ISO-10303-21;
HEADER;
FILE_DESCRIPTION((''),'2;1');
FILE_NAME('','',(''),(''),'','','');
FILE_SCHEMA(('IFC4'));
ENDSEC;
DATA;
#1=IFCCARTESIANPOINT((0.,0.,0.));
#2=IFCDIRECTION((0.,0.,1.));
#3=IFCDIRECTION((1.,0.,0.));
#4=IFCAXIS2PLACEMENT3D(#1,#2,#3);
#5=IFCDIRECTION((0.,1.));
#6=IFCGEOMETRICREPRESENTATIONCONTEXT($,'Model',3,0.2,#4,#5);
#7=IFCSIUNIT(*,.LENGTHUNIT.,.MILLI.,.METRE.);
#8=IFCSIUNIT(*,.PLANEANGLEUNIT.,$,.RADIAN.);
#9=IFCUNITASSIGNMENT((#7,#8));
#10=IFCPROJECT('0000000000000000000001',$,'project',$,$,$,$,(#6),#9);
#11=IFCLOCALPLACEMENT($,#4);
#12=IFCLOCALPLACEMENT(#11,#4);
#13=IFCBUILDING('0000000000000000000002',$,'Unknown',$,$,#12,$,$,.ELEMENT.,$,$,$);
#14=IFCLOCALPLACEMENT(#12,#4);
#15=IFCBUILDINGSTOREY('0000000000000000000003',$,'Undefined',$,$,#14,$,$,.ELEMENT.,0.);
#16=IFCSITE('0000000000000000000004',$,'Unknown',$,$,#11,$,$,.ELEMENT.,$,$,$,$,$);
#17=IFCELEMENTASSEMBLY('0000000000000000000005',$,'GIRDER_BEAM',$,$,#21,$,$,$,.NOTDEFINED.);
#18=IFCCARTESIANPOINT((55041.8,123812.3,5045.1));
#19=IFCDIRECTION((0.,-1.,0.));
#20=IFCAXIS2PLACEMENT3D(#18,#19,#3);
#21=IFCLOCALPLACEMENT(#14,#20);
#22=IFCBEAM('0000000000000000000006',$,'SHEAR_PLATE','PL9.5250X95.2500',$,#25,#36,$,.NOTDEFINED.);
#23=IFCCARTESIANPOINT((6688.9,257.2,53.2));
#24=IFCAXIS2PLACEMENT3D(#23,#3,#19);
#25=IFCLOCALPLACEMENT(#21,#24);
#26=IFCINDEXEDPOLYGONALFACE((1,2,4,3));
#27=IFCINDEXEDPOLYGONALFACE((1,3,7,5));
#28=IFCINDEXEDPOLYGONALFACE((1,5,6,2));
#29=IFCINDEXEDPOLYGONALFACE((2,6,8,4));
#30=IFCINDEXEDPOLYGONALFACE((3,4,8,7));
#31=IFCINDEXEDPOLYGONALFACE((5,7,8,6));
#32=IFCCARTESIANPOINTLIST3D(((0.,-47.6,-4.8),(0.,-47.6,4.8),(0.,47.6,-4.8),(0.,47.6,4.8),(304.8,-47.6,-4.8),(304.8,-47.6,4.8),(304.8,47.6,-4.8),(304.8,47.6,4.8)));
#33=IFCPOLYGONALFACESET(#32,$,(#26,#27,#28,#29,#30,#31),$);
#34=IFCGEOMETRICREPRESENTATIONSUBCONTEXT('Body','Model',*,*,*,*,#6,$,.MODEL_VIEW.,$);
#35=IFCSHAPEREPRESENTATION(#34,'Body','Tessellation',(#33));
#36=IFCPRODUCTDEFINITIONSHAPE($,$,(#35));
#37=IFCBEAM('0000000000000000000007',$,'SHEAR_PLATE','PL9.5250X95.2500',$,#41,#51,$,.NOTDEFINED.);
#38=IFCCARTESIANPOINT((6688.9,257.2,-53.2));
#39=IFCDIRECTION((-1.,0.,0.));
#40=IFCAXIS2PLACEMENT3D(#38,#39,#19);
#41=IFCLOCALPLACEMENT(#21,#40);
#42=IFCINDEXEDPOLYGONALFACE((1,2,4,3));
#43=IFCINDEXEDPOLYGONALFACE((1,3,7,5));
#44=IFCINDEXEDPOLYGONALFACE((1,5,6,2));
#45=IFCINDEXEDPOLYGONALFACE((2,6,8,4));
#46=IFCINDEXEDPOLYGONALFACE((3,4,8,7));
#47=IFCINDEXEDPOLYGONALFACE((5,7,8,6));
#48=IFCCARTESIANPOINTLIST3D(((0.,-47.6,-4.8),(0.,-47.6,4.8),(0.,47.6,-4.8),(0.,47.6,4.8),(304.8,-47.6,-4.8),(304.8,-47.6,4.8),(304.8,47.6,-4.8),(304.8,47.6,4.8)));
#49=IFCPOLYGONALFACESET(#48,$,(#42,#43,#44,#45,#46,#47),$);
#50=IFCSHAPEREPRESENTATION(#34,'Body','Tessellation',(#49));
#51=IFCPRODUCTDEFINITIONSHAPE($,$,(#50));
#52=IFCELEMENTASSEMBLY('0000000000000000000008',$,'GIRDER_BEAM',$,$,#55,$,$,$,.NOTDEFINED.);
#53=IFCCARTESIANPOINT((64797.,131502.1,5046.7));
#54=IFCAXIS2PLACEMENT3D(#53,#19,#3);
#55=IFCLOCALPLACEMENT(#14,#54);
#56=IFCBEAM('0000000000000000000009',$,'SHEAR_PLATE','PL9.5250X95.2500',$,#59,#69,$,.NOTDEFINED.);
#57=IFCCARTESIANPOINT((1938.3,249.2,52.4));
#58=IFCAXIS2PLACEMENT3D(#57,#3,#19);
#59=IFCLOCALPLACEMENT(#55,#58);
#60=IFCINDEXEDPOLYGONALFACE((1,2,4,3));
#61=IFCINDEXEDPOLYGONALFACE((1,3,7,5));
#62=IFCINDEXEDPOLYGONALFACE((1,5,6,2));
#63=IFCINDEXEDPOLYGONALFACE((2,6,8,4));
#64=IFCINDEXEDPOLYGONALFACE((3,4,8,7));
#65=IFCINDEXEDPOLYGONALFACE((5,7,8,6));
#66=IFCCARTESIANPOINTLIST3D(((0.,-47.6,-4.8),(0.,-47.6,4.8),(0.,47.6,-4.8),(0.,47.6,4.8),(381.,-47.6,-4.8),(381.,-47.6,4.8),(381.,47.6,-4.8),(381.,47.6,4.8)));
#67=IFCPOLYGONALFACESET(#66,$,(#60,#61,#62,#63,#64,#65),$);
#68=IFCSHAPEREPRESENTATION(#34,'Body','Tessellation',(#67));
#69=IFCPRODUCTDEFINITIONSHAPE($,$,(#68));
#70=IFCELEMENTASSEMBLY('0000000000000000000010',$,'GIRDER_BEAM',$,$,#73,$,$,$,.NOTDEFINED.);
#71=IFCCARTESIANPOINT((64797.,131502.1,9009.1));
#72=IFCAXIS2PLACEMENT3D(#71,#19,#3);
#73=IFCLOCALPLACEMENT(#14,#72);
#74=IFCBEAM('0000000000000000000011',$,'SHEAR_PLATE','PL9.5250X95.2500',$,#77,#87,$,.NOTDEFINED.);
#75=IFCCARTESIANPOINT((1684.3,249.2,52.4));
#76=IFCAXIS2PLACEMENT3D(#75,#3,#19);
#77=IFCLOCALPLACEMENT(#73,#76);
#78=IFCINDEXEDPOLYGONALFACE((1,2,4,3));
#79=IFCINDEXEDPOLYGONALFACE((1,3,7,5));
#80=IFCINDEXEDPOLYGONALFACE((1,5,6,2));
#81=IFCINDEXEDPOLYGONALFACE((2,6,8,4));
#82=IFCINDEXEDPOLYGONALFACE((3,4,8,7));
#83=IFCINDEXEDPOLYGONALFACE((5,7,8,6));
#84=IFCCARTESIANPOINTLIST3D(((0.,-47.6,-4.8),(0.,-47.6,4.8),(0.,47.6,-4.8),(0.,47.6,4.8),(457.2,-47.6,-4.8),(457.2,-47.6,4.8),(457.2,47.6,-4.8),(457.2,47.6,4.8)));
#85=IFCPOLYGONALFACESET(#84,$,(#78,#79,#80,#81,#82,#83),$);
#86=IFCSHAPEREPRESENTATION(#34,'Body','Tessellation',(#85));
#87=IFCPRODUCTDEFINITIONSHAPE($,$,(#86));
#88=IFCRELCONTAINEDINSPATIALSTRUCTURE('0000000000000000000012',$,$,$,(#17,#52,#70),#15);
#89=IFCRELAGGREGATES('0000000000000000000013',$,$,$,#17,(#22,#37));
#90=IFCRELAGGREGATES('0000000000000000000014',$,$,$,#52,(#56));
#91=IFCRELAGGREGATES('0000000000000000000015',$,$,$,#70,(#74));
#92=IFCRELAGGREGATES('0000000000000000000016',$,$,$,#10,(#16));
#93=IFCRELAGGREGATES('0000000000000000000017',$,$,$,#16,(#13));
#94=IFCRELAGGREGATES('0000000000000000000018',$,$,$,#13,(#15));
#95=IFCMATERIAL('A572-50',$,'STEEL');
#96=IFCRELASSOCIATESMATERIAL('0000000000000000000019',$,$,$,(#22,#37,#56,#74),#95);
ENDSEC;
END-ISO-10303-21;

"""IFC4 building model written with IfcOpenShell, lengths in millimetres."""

from ifc_helpers import new_model, si_unit, direction, frame, origin_with_axes, place, context, subcontext, project, spatial, line, indexed_curve, outline, extrude, material, element, aggregate, save


model = new_model("IFC4")

# Units and contexts
model_context = context("Model", 3, precision=0.2, world=origin_with_axes(), true_north=direction((0.0, 1.0)))
body_context = subcontext(model_context, "Body", "Model", "MODEL_VIEW")
ifc_project = project(units=[si_unit("LENGTHUNIT", "METRE", prefix="MILLI"), si_unit("PLANEANGLEUNIT", "RADIAN")], contexts=[model_context])

# Site, building, storey
site_placement = place(None, origin_with_axes())
site = spatial("IfcSite", under=ifc_project, at=site_placement, Name="Unknown", CompositionType="ELEMENT")
building_placement = place(site_placement, origin_with_axes())
building = spatial("IfcBuilding", under=site, at=building_placement, Name="Unknown", CompositionType="ELEMENT")
storey_placement = place(building_placement, origin_with_axes())
storey = spatial("IfcBuildingStorey", under=building, at=storey_placement, Name="Undefined", CompositionType="ELEMENT", Elevation=0.0)

# Element assembly, beams
assembly_1_placement = place(storey_placement, frame((55041.8, 123812.3, 5045.1), z_axis=(0.0, -1.0, 0.0), x_axis=(1.0, 0.0, 0.0)))
assembly_1 = element("IfcElementAssembly", 1, at=assembly_1_placement, inside=storey, Name="GIRDER_BEAM", PredefinedType="NOTDEFINED")
ifc_material_1 = material(Name="A572-50", Category="STEEL")
beam_1_placement = place(assembly_1_placement, frame((6688.9, 257.2, 53.2), z_axis=(1.0, 0.0, 0.0), x_axis=(0.0, -1.0, 0.0)))
beam_1 = element("IfcBeam", 2, at=beam_1_placement, material=ifc_material_1, Name="SHEAR_PLATE", Description="PL9.5250X95.2500", PredefinedType="NOTDEFINED", context=body_context, shape_type="SolidModel", body=[
    extrude(outline(indexed_curve([(-4.8, -47.6), (4.8, -47.6), (4.8, 47.6), (-4.8, 47.6)], segments=[line(1, 2, 3, 4, 1)])), frame((0.0, 0.0, 0.0), z_axis=(-1.0, 0.0, 0.0), x_axis=(0.0, 0.0, 1.0)), (0.0, 0.0, -1.0), 304.8),
])
beam_2_placement = place(assembly_1_placement, frame((6688.9, 257.2, -53.2), z_axis=(-1.0, 0.0, 0.0), x_axis=(0.0, -1.0, 0.0)))
beam_2 = element("IfcBeam", 3, at=beam_2_placement, material=ifc_material_1, Name="SHEAR_PLATE", Description="PL9.5250X95.2500", PredefinedType="NOTDEFINED", context=body_context, shape_type="SolidModel", body=[
    extrude(outline(indexed_curve([(-4.8, -47.6), (4.8, -47.6), (4.8, 47.6), (-4.8, 47.6)], segments=[line(1, 2, 3, 4, 1)])), frame((0.0, 0.0, 0.0), z_axis=(-1.0, 0.0, 0.0), x_axis=(0.0, 0.0, 1.0)), (0.0, 0.0, -1.0), 304.8),
])
aggregate(assembly_1, [beam_1, beam_2])

# Element assemblies, beams
assembly_2_placement = place(storey_placement, frame((64797.0, 131502.1, 5046.7), z_axis=(0.0, -1.0, 0.0), x_axis=(1.0, 0.0, 0.0)))
assembly_2 = element("IfcElementAssembly", 4, at=assembly_2_placement, inside=storey, Name="GIRDER_BEAM", PredefinedType="NOTDEFINED")
beam_3_placement = place(assembly_2_placement, frame((1938.3, 249.2, 52.4), z_axis=(1.0, 0.0, 0.0), x_axis=(0.0, -1.0, 0.0)))
beam_3 = element("IfcBeam", 5, at=beam_3_placement, material=ifc_material_1, Name="SHEAR_PLATE", Description="PL9.5250X95.2500", PredefinedType="NOTDEFINED", context=body_context, shape_type="SolidModel", body=[
    extrude(outline(indexed_curve([(-4.8, -47.6), (4.8, -47.6), (4.8, 47.6), (-4.8, 47.6)], segments=[line(1, 2, 3, 4, 1)])), frame((0.0, 0.0, 0.0), z_axis=(-1.0, 0.0, 0.0), x_axis=(0.0, 0.0, 1.0)), (0.0, 0.0, -1.0), 381.0),
])
aggregate(assembly_2, [beam_3])
assembly_3_placement = place(storey_placement, frame((64797.0, 131502.1, 9009.1), z_axis=(0.0, -1.0, 0.0), x_axis=(1.0, 0.0, 0.0)))
assembly_3 = element("IfcElementAssembly", 6, at=assembly_3_placement, inside=storey, Name="GIRDER_BEAM", PredefinedType="NOTDEFINED")
beam_4_placement = place(assembly_3_placement, frame((1684.3, 249.2, 52.4), z_axis=(1.0, 0.0, 0.0), x_axis=(0.0, -1.0, 0.0)))
beam_4 = element("IfcBeam", 7, at=beam_4_placement, material=ifc_material_1, Name="SHEAR_PLATE", Description="PL9.5250X95.2500", PredefinedType="NOTDEFINED", context=body_context, shape_type="SolidModel", body=[
    extrude(outline(indexed_curve([(-4.8, -47.6), (4.8, -47.6), (4.8, 47.6), (-4.8, 47.6)], segments=[line(1, 2, 3, 4, 1)])), frame((0.0, 0.0, 0.0), z_axis=(-1.0, 0.0, 0.0), x_axis=(0.0, 0.0, 1.0)), (0.0, 0.0, -1.0), 457.2),
])
aggregate(assembly_3, [beam_4])

save(model, "model.ifc")
